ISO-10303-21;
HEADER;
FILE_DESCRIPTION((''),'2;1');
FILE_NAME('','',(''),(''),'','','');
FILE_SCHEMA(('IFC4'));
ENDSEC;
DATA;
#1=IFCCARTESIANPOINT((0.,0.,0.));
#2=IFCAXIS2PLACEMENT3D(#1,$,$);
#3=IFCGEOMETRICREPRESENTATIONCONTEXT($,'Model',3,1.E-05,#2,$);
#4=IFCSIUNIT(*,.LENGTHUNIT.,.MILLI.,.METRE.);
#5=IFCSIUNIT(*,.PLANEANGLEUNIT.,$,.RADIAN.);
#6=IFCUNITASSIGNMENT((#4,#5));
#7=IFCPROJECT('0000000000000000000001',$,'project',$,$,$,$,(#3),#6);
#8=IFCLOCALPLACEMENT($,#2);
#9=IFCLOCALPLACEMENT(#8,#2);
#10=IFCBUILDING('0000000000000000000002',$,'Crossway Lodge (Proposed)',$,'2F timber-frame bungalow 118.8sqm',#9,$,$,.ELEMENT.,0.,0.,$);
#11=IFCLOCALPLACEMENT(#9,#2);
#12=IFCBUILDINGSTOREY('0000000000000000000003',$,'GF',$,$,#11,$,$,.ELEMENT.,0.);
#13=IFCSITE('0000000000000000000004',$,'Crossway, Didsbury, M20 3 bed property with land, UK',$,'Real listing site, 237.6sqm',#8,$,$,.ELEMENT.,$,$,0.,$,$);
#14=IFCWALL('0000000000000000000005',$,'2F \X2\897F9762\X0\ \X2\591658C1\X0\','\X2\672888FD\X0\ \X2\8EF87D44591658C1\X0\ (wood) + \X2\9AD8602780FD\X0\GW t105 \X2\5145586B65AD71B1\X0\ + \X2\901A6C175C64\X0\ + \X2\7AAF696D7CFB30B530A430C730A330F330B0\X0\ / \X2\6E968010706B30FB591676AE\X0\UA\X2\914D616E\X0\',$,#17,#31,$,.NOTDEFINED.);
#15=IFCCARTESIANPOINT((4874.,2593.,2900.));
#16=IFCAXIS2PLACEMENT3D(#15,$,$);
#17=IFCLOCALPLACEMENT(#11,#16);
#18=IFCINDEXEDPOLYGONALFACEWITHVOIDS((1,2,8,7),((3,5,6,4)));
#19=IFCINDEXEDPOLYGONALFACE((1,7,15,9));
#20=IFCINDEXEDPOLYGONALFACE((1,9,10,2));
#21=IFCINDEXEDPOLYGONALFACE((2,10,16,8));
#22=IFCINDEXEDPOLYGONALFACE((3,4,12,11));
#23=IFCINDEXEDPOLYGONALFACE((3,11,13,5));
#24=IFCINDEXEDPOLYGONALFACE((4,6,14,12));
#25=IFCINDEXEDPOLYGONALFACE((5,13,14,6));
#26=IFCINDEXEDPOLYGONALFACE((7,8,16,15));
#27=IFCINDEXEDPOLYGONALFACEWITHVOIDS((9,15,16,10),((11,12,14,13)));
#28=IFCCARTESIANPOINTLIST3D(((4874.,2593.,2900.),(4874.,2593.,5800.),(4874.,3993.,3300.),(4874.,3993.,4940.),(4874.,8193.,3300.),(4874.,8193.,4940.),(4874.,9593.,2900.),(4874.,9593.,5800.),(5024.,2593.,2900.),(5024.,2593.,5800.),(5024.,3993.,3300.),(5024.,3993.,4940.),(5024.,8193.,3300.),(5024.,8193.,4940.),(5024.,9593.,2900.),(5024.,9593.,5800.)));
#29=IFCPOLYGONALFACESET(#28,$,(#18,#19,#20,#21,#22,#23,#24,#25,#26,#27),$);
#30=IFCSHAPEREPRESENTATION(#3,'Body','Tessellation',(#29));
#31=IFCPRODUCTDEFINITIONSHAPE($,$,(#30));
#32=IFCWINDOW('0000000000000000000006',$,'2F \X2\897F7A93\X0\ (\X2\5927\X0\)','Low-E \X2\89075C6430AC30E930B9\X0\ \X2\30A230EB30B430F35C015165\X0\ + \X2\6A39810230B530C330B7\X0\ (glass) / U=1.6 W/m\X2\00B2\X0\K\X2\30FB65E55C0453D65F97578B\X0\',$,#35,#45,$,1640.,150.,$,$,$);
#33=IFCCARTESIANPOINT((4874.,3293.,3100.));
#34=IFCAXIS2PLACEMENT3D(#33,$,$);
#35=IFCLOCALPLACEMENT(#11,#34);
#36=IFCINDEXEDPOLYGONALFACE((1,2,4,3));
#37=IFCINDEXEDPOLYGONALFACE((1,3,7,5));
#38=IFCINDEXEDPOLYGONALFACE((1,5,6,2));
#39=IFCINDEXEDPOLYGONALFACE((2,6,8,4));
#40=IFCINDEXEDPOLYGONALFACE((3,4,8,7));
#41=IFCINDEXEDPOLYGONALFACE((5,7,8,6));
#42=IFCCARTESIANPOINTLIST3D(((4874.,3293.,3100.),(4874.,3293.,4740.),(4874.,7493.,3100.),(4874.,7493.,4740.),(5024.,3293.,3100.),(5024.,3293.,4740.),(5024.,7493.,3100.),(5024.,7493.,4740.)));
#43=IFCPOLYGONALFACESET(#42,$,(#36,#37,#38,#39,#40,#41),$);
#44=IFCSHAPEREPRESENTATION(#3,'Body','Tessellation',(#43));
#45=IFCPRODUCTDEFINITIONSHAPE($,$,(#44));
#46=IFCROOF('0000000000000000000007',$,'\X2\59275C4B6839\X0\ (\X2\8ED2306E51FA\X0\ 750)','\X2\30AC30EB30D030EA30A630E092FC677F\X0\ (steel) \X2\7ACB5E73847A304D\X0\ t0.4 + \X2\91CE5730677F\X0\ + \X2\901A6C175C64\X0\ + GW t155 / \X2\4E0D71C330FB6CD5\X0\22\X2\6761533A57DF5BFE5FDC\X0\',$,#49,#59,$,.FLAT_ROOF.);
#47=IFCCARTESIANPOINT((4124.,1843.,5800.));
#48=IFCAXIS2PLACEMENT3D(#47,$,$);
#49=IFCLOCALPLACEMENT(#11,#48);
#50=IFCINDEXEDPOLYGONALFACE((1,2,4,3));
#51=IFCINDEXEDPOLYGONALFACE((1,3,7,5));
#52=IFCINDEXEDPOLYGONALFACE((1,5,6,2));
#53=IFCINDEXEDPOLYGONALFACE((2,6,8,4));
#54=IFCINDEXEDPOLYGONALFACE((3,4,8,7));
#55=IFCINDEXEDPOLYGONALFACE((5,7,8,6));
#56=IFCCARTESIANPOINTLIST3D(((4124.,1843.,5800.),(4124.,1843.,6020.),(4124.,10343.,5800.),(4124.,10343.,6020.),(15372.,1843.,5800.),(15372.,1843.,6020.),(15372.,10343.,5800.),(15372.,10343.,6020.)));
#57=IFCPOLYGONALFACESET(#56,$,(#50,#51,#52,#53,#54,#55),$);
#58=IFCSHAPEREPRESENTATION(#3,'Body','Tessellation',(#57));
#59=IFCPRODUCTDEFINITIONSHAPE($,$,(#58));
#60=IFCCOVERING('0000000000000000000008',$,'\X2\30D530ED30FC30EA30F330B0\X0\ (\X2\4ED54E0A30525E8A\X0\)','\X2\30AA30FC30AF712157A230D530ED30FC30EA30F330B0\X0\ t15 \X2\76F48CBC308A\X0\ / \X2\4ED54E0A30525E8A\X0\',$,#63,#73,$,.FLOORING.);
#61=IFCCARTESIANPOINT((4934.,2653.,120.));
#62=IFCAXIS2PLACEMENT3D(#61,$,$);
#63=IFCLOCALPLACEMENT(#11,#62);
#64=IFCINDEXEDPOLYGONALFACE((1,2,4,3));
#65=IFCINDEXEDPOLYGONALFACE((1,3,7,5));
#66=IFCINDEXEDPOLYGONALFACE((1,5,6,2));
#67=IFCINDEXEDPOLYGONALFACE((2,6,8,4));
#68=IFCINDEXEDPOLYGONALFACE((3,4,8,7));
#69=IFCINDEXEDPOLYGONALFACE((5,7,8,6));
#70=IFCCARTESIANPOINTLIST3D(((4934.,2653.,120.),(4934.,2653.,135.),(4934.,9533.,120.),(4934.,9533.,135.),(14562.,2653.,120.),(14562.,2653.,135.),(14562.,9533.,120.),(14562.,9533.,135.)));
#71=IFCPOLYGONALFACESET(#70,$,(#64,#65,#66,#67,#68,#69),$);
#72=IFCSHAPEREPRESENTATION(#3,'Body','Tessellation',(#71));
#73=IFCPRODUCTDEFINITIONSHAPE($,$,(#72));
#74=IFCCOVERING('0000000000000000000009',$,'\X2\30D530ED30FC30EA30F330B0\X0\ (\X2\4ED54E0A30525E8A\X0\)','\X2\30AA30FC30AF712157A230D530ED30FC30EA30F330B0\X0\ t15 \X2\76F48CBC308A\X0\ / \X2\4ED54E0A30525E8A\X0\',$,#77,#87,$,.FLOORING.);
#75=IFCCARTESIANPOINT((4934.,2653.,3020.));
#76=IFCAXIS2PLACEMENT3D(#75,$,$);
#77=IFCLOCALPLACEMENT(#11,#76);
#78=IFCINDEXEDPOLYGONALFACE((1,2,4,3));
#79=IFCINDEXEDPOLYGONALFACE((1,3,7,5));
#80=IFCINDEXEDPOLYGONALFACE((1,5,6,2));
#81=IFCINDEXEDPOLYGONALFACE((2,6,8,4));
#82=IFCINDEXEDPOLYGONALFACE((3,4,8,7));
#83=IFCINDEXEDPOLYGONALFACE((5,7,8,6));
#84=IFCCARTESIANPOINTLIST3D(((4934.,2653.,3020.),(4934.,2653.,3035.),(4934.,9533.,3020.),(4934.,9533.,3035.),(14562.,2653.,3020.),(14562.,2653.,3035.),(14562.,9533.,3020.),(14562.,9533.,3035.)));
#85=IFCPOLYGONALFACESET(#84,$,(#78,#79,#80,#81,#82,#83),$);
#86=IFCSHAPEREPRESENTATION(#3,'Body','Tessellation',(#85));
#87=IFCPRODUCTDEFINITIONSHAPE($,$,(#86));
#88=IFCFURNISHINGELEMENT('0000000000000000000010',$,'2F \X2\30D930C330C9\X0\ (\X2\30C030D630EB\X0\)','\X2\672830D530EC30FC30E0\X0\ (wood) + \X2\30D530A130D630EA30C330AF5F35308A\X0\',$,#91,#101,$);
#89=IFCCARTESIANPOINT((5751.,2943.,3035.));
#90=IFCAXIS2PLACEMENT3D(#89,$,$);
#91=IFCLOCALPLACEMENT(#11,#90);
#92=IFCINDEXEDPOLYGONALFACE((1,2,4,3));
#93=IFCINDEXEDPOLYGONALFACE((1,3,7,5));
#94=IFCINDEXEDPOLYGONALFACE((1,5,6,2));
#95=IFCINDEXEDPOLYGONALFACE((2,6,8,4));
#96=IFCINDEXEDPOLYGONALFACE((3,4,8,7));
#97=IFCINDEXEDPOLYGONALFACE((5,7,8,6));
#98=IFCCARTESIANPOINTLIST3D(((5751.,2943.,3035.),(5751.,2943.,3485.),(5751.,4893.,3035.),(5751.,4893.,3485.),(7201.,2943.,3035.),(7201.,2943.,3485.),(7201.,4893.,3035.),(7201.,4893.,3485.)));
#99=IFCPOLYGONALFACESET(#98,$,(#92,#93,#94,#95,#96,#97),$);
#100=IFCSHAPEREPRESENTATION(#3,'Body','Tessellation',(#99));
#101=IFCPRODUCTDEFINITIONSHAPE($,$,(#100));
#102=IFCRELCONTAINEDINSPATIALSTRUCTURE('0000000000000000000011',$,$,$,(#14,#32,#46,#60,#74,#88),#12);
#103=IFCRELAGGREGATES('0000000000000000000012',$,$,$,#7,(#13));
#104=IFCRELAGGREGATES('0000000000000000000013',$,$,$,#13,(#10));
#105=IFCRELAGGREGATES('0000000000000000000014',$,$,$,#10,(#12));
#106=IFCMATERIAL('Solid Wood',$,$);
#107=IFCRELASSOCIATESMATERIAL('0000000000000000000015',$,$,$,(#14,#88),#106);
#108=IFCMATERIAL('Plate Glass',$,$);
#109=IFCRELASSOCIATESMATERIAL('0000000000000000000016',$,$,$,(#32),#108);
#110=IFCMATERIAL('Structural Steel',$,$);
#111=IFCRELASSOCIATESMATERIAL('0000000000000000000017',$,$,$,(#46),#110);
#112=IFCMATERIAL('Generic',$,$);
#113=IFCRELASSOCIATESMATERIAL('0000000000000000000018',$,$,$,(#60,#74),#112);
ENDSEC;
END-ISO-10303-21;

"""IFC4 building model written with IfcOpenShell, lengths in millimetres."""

from ifc_helpers import new_model, si_unit, frame, frame_2d, origin, place, context, project, spatial, rectangle, extrude, material, element, fill, save


model = new_model("IFC4")

# Units and contexts
model_context = context("Model", 3, precision=1e-05, world=origin())
ifc_project = project(units=[si_unit("LENGTHUNIT", "METRE", prefix="MILLI"), si_unit("PLANEANGLEUNIT", "RADIAN")], contexts=[model_context])

# Site, building, storey
site_placement = place(None, origin())
site = spatial("IfcSite", under=ifc_project, at=site_placement, Name="Crossway, Didsbury, M20 3 bed property with land, UK", ObjectType="Real listing site, 237.6sqm", CompositionType="ELEMENT", RefElevation=0.0)
building_placement = place(site_placement, origin())
building = spatial("IfcBuilding", under=site, at=building_placement, Name="Crossway Lodge (Proposed)", ObjectType="2F timber-frame bungalow 118.8sqm", CompositionType="ELEMENT", ElevationOfRefHeight=0.0, ElevationOfTerrain=0.0)
storey_placement = place(building_placement, origin())
storey = spatial("IfcBuildingStorey", under=building, at=storey_placement, Name="GF", CompositionType="ELEMENT", Elevation=0.0)

# Shared definitions
ifc_material_1 = material(Name="Solid Wood")

# Shared definitions
ifc_material_2 = material(Name="Plate Glass")

# Wall, opening, window
wall_1_placement = place(storey_placement, frame((4874.0, 2593.0, 2900.0)))
wall_1 = element("IfcWall", 1, at=wall_1_placement, inside=storey, material=ifc_material_1, Name="2F 西面 外壁", Description="木製 軸組外壁 (wood) + 高性能GW t105 充填断熱 + 通気層 + 窯業系サイディング / 準耐火・外皮UA配慮", PredefinedType="NOTDEFINED", context=model_context, shape_type="SweptSolid", body=[
    extrude(rectangle(XDim=150.0, YDim=7000.0, at=frame_2d((75.0, 3500.0))), frame((4874.0, 2593.0, 2900.0)), (0.0, 0.0, 1.0), 2900.0),
])
opening_1_placement = place(storey_placement, frame((4874.0, 3293.0, 3100.0)))
opening_1 = element("IfcOpeningElement", 2, at=opening_1_placement, cuts=wall_1, PredefinedType="NOTDEFINED", context=model_context, shape_type="SweptSolid", body=[
    extrude(rectangle(XDim=150.0, YDim=4200.0, at=frame_2d((75.0, 2100.0))), frame((4874.0, 3293.0, 3100.0)), (0.0, 0.0, 1.0), 1640.0),
])
window_1_placement = place(storey_placement, frame((4874.0, 3293.0, 3100.0)))
window_1 = element("IfcWindow", 3, at=window_1_placement, inside=storey, material=ifc_material_2, Name="2F 西窓 (大)", Description="Low-E 複層ガラス アルゴン封入 + 樹脂サッシ (glass) / U=1.6 W/m²K・日射取得型", OverallHeight=1640.0, OverallWidth=150.0, context=model_context, shape_type="SweptSolid", body=[
    extrude(rectangle(XDim=150.0, YDim=4200.0, at=frame_2d((75.0, 2100.0))), frame((4874.0, 3293.0, 3100.0)), (0.0, 0.0, 1.0), 1640.0),
])
fill(opening_1, window_1)

# Roof
ifc_material_3 = material(Name="Structural Steel")
roof_placement = place(storey_placement, frame((4124.0, 1843.0, 5800.0)))
element("IfcRoof", 4, at=roof_placement, inside=storey, material=ifc_material_3, Name="大屋根 (軒の出 750)", Description="ガルバリウム鋼板 (steel) 立平葺き t0.4 + 野地板 + 通気層 + GW t155 / 不燃・法22条区域対応", PredefinedType="FLAT_ROOF", context=model_context, shape_type="SweptSolid", body=[
    extrude(rectangle(XDim=11248.0, YDim=8500.0, at=frame_2d((5624.0, 4250.0))), frame((4124.0, 1843.0, 5800.0)), (0.0, 0.0, 1.0), 220.0),
])

# Coverings
ifc_material_4 = material(Name="Generic")
covering_1_placement = place(storey_placement, frame((4934.0, 2653.0, 120.0)))
element("IfcCovering", 5, at=covering_1_placement, inside=storey, material=ifc_material_4, Name="フローリング (仕上げ床)", Description="オーク無垢フローリング t15 直貼り / 仕上げ床", PredefinedType="FLOORING", context=model_context, shape_type="SweptSolid", body=[
    extrude(rectangle(XDim=9628.0, YDim=6880.0, at=frame_2d((4814.0, 3440.0))), frame((4934.0, 2653.0, 120.0)), (0.0, 0.0, 1.0), 15.0),
])
covering_2_placement = place(storey_placement, frame((4934.0, 2653.0, 3020.0)))
element("IfcCovering", 6, at=covering_2_placement, inside=storey, material=ifc_material_4, Name="フローリング (仕上げ床)", Description="オーク無垢フローリング t15 直貼り / 仕上げ床", PredefinedType="FLOORING", context=model_context, shape_type="SweptSolid", body=[
    extrude(rectangle(XDim=9628.0, YDim=6880.0, at=frame_2d((4814.0, 3440.0))), frame((4934.0, 2653.0, 3020.0)), (0.0, 0.0, 1.0), 15.0),
])

# Furnishing element
furnishing_placement = place(storey_placement, frame((5751.0, 2943.0, 3035.0)))
element("IfcFurnishingElement", 7, at=furnishing_placement, inside=storey, material=ifc_material_1, Name="2F ベッド (ダブル)", Description="木フレーム (wood) + ファブリック張り", context=model_context, shape_type="SweptSolid", body=[
    extrude(rectangle(XDim=1450.0, YDim=1950.0, at=frame_2d((725.0, 975.0))), frame((5751.0, 2943.0, 3035.0)), (0.0, 0.0, 1.0), 450.0),
])

save(model, "model.ifc")
